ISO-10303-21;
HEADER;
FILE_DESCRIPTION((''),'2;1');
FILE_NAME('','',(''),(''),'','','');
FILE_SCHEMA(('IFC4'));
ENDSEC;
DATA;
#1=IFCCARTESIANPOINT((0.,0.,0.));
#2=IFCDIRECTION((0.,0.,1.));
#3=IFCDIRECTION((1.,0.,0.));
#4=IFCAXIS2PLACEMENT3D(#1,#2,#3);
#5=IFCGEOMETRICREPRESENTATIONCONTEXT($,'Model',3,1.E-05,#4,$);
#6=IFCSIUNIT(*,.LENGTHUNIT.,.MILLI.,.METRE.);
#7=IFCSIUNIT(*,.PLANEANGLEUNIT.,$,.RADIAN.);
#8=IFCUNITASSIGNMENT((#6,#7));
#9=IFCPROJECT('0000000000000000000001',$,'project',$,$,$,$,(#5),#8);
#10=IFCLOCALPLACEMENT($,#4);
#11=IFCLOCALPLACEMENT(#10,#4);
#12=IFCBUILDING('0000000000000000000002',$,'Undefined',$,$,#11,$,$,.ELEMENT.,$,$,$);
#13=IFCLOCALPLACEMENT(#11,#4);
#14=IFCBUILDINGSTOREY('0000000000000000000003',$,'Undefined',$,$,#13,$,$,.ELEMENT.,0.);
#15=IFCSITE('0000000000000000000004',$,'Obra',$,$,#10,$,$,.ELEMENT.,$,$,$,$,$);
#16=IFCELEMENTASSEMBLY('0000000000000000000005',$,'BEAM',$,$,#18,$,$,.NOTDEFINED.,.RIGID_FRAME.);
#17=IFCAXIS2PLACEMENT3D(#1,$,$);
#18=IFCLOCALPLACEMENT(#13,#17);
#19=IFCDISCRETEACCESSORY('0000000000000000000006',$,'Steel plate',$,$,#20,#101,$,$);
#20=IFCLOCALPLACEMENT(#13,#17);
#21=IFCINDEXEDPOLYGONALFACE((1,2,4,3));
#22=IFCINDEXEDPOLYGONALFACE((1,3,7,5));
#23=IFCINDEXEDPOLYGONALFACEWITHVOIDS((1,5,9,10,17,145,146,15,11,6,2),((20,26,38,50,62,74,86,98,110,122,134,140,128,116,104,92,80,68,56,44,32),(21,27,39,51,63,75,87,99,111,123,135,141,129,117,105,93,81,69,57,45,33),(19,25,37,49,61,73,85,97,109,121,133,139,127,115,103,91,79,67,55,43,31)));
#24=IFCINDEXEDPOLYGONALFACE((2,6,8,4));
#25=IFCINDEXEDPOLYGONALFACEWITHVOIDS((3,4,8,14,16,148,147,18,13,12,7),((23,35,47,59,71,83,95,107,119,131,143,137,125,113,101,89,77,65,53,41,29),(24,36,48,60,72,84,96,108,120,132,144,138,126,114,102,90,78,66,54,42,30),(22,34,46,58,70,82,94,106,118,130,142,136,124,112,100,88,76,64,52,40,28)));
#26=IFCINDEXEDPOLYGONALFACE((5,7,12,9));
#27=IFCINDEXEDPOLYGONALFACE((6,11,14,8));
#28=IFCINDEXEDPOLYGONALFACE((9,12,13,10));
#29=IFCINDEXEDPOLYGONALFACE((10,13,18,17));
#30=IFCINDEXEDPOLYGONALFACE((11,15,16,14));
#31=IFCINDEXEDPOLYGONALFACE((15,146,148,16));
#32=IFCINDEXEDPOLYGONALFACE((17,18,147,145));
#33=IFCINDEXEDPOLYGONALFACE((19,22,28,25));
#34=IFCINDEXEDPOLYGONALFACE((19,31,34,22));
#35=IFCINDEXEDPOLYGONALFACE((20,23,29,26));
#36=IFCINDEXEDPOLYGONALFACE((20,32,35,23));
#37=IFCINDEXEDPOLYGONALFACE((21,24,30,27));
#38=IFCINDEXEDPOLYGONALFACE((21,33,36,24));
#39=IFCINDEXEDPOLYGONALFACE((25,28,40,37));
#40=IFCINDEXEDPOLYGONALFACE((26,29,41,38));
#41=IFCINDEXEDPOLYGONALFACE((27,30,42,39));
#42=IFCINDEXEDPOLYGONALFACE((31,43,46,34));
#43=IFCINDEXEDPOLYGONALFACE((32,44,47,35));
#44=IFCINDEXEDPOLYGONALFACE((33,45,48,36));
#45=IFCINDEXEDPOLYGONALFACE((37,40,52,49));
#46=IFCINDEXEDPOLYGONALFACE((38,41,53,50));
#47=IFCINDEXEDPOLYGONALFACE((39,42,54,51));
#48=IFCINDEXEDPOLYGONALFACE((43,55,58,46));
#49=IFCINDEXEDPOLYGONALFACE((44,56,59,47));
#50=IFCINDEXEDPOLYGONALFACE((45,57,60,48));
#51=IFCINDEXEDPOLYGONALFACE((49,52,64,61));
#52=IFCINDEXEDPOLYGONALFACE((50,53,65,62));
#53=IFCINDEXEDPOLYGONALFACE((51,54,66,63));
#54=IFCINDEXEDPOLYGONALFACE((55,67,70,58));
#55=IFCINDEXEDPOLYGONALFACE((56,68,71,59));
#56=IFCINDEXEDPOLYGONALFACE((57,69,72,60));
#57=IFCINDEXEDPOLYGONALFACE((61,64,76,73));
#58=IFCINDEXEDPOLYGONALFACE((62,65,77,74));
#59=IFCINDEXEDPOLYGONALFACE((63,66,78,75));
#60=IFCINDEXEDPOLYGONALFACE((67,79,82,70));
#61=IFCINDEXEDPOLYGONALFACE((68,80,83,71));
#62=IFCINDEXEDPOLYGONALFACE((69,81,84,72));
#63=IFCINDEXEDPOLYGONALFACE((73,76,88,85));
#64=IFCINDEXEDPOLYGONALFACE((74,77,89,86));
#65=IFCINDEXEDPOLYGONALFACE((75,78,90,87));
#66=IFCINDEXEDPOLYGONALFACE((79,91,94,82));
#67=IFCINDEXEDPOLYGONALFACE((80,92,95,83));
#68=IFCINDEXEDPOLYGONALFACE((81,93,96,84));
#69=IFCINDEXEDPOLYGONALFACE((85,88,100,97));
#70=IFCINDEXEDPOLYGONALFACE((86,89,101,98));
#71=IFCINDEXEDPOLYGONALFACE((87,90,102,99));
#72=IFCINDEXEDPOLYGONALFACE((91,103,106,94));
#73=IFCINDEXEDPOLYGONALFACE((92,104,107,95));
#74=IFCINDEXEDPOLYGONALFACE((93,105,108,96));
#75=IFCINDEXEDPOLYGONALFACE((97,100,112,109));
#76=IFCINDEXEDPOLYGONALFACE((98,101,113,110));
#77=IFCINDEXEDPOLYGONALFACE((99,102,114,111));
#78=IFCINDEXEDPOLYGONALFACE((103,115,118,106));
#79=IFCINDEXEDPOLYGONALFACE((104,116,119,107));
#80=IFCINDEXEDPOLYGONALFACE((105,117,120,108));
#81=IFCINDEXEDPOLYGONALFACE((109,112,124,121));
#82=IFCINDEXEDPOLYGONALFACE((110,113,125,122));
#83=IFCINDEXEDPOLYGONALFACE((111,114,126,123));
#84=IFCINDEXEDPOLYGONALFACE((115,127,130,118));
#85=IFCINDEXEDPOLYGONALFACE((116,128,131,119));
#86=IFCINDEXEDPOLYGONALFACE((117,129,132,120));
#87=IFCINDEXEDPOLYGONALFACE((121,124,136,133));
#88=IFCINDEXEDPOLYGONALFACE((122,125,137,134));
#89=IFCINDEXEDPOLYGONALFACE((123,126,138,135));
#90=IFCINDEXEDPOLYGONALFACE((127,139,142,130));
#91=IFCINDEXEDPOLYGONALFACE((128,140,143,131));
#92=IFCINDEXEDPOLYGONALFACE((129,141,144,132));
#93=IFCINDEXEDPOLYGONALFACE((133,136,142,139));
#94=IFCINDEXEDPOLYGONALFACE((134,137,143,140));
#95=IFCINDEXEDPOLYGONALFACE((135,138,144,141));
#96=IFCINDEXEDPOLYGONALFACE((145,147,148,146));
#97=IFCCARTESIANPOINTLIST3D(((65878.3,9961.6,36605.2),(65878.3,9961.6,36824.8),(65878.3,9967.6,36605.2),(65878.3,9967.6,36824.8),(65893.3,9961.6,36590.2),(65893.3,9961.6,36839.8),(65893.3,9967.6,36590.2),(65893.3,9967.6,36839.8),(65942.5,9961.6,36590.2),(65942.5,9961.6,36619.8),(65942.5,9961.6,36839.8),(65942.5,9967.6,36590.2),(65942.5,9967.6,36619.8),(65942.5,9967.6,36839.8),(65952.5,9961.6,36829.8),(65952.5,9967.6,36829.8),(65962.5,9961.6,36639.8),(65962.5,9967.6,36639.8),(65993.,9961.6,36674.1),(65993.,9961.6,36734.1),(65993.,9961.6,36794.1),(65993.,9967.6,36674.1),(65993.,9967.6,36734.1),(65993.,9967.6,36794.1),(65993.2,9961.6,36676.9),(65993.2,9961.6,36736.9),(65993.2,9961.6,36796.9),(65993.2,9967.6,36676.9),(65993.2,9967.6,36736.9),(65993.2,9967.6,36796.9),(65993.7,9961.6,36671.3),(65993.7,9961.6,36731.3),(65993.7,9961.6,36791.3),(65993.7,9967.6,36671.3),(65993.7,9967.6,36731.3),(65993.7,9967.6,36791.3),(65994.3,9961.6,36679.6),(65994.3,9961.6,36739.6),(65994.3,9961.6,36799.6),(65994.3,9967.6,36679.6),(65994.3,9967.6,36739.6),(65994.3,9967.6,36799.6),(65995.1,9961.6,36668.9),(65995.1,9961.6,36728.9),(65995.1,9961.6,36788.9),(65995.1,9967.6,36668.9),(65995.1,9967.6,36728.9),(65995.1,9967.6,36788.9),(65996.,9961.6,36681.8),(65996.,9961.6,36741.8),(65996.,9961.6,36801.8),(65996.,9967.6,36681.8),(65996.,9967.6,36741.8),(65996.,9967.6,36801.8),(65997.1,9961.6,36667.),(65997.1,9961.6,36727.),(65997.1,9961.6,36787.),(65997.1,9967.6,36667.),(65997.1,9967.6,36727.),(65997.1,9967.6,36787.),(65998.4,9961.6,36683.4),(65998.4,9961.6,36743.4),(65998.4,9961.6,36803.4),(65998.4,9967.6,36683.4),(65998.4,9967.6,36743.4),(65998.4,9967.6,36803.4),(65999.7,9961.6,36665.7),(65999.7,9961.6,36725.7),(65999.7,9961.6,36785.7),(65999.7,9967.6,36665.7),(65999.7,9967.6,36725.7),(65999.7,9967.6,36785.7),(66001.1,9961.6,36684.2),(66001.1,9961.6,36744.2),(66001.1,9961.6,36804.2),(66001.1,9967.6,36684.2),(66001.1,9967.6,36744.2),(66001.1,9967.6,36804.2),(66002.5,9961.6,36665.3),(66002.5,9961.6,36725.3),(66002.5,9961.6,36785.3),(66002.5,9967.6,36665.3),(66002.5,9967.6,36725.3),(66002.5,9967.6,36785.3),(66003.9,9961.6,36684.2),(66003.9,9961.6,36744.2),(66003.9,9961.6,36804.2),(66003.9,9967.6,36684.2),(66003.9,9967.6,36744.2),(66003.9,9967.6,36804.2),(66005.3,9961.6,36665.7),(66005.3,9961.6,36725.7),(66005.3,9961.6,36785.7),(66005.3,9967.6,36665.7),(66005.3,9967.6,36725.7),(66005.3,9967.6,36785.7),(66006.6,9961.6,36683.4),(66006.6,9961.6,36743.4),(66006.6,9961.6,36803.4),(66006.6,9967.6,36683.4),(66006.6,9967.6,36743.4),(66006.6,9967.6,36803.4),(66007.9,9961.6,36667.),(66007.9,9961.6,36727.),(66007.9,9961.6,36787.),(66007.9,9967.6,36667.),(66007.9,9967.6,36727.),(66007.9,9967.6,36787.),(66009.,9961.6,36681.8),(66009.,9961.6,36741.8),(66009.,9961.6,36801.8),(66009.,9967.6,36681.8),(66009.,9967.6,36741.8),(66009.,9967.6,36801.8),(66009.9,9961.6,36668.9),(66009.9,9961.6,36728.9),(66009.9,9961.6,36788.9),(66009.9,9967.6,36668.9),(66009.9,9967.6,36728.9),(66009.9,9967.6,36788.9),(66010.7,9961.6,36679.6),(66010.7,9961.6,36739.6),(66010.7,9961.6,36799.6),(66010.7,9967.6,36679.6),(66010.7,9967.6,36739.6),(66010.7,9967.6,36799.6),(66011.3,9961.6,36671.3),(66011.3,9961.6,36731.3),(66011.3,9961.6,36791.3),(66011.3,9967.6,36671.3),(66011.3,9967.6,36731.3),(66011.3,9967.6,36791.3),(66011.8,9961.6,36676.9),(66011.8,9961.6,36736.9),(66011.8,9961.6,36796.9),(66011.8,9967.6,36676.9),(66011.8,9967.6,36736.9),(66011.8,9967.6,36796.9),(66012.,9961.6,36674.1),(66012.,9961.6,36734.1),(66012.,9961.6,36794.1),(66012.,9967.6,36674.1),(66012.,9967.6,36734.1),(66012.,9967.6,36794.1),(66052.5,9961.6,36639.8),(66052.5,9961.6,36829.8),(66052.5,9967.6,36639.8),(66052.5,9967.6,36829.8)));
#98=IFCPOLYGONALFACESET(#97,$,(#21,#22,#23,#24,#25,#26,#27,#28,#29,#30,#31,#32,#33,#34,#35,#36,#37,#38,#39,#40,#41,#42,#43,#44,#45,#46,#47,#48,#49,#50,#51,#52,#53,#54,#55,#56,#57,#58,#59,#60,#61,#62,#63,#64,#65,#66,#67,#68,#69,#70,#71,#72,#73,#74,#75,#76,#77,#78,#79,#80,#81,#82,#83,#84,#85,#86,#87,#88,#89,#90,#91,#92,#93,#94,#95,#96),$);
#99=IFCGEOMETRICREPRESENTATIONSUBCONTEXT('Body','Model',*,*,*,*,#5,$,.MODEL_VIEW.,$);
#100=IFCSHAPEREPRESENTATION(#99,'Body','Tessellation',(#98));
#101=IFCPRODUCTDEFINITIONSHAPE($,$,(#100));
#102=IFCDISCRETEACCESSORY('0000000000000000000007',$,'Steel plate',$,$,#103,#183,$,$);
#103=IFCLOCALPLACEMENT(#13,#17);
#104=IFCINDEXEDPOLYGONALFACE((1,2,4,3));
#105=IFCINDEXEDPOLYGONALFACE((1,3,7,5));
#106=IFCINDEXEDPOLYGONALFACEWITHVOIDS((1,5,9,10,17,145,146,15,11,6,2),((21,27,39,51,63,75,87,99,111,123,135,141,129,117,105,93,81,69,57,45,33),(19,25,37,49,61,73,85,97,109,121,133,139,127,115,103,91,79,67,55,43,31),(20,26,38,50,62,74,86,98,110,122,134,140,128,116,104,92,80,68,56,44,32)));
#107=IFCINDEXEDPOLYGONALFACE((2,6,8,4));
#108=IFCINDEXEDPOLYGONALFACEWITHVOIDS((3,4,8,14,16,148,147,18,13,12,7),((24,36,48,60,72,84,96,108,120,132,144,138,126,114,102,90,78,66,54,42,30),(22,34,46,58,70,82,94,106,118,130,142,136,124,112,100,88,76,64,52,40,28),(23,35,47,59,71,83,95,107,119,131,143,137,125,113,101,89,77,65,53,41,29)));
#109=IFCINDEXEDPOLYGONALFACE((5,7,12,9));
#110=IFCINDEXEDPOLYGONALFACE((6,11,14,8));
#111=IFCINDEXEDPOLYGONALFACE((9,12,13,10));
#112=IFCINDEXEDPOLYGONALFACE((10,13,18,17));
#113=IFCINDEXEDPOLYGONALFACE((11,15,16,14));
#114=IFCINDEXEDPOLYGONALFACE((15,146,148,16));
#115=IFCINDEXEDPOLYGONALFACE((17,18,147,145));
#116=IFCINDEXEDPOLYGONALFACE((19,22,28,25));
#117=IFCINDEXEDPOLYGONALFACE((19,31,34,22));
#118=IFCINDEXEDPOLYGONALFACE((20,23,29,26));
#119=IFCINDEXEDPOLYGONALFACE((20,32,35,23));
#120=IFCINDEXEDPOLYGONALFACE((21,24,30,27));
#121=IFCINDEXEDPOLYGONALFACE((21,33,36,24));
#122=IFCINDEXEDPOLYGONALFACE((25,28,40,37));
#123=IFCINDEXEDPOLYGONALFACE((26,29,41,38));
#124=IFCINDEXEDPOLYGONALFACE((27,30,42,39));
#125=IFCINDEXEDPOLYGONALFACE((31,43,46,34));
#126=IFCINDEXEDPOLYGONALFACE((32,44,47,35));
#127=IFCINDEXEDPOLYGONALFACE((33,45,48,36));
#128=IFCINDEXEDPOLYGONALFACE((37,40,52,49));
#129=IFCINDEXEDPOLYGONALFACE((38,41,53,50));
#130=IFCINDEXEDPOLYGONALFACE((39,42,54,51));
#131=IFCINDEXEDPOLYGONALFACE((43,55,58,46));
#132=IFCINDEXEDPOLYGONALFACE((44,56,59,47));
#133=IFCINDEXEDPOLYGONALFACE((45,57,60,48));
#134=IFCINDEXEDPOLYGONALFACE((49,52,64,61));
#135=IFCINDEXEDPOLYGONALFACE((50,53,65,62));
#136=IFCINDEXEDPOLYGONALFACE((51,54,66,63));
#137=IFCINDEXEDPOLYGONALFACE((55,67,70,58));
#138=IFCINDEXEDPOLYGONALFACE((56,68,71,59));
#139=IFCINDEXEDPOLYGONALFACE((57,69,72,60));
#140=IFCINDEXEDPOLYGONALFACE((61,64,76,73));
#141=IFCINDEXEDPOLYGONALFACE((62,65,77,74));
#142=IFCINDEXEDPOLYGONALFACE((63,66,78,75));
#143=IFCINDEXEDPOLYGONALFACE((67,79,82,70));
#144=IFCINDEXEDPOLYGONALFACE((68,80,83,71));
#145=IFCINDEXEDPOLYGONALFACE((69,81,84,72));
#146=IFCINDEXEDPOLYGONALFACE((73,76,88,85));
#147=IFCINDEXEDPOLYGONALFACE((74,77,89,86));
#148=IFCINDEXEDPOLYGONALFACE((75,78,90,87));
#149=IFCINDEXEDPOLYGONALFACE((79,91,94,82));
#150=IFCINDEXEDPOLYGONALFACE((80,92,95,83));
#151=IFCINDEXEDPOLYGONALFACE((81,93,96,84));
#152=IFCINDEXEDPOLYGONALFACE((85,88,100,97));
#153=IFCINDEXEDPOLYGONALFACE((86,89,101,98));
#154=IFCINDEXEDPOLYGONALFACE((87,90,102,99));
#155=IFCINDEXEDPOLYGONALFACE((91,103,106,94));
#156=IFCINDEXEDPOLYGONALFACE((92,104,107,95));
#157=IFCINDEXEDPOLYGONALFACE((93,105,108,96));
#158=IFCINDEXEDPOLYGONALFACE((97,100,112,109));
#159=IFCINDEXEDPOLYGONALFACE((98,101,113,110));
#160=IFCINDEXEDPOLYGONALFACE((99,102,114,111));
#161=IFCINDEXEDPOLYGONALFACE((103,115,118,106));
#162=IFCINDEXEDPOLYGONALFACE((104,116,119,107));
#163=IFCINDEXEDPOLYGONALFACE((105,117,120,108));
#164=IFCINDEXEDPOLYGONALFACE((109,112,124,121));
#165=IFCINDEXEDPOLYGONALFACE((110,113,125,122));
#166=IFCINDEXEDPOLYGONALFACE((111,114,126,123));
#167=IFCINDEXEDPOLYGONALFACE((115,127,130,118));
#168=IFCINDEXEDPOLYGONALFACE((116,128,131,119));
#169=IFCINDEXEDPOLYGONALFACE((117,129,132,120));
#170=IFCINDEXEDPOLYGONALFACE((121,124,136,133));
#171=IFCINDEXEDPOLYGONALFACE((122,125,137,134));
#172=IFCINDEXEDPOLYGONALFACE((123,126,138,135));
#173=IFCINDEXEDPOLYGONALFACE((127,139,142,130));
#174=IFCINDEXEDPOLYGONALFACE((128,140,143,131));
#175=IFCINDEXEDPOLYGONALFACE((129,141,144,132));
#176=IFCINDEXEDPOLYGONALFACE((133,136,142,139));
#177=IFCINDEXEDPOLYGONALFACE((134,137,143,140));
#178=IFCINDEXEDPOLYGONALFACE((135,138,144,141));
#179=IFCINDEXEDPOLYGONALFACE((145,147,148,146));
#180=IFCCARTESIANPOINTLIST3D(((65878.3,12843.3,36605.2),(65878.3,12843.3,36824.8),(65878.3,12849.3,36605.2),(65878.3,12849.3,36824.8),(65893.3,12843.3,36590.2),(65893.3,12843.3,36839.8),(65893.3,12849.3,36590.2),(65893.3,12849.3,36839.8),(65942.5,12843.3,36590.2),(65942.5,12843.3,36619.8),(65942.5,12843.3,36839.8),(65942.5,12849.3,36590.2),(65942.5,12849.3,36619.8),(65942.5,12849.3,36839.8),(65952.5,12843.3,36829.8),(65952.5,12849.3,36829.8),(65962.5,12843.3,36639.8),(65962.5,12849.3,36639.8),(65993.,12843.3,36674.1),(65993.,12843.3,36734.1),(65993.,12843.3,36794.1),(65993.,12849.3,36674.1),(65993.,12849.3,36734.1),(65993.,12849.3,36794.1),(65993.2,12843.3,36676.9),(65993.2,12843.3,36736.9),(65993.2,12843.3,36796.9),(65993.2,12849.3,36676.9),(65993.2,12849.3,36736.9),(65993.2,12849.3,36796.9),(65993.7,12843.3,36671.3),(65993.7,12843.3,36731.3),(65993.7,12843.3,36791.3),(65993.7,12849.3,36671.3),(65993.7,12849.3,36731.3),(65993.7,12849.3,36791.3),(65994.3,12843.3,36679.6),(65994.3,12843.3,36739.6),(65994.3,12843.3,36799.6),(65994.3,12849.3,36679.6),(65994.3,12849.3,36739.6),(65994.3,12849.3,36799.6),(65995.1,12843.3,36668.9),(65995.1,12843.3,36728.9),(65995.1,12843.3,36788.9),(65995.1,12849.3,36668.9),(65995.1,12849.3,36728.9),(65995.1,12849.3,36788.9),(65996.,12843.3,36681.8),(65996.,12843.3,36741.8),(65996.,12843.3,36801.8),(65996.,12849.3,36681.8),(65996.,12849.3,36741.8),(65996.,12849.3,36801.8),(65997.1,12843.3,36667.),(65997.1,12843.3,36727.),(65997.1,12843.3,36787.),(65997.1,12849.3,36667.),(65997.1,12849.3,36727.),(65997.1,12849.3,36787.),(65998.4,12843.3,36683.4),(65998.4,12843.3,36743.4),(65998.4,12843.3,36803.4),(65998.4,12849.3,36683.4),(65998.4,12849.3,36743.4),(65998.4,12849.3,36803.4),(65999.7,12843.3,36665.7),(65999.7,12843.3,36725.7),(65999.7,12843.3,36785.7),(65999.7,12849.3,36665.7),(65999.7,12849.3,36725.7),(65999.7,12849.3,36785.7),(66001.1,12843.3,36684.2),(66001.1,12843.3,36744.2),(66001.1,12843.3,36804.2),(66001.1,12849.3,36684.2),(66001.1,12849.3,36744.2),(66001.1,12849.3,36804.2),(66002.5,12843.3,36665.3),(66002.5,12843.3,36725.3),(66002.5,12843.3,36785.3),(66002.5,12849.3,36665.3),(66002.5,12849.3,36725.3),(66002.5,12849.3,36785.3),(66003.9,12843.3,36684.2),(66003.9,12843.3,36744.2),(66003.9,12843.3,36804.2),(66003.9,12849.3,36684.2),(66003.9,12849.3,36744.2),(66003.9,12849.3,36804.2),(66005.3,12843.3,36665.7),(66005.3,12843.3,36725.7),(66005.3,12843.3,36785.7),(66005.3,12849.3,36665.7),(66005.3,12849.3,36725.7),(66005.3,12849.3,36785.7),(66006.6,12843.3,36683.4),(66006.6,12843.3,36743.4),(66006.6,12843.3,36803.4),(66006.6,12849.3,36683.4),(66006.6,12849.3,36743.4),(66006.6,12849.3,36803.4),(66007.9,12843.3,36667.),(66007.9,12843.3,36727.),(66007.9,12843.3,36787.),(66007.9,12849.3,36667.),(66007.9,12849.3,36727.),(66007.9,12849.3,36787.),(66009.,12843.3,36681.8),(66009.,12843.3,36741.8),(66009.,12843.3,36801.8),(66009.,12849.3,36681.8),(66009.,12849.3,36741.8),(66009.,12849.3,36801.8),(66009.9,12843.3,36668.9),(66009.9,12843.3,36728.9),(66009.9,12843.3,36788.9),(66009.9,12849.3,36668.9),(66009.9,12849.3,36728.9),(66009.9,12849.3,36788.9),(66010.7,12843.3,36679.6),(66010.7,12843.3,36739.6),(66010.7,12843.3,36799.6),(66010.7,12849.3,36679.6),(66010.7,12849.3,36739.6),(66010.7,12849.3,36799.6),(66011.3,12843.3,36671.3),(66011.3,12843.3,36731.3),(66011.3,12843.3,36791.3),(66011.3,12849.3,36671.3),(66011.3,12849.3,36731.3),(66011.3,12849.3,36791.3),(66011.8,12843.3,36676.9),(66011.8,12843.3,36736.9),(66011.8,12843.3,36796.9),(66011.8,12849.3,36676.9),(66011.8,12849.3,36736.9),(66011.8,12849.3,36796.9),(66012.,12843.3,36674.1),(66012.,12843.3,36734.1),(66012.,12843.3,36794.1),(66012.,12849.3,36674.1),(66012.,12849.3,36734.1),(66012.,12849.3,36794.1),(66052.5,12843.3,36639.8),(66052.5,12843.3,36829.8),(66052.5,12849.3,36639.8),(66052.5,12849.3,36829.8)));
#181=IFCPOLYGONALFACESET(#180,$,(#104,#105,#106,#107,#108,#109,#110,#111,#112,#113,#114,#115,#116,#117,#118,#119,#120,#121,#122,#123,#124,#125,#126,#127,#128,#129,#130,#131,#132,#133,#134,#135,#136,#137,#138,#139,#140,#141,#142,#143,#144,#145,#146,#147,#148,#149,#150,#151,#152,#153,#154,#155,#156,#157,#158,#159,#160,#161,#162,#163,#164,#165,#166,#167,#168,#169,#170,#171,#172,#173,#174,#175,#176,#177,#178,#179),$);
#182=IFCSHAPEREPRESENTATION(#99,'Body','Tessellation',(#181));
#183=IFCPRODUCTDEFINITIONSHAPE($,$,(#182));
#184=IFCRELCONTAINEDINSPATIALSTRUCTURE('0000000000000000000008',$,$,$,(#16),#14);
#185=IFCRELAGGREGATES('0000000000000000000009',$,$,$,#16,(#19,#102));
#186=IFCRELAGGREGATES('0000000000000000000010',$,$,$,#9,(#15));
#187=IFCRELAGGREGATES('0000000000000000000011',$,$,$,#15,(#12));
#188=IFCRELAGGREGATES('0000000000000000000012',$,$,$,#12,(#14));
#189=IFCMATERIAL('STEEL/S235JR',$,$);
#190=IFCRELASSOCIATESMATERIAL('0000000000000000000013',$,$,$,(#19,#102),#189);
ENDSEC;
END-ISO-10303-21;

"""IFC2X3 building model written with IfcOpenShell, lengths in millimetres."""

from ifc_helpers import new_model, si_unit, frame, origin_with_axes, origin_2d_with_axis, place, context, subcontext, project, spatial, polyline, circle, outline, extrude, source, transform, mapped, material, element, aggregate, save


model = new_model("IFC2X3")

# Units and contexts
model_context = context("Model", 3, precision=1e-05, world=origin_with_axes())
body_context = subcontext(model_context, "Body", "Model", "MODEL_VIEW")
ifc_project = project(units=[si_unit("LENGTHUNIT", "METRE", prefix="MILLI"), si_unit("PLANEANGLEUNIT", "RADIAN")], contexts=[model_context])

# Site, building, storey
site_placement = place(None, origin_with_axes())
site = spatial("IfcSite", under=ifc_project, at=site_placement, Name="Obra", CompositionType="ELEMENT")
building_placement = place(site_placement, origin_with_axes())
building = spatial("IfcBuilding", under=site, at=building_placement, Name="Undefined", CompositionType="ELEMENT")
storey_placement = place(building_placement, origin_with_axes())
storey = spatial("IfcBuildingStorey", under=building, at=storey_placement, Name="Undefined", CompositionType="ELEMENT", Elevation=0.0)

# Element assembly
assembly_1_placement = place(storey_placement, origin_with_axes())
assembly_1 = element("IfcElementAssembly", 1, at=assembly_1_placement, inside=storey, Name="BEAM", AssemblyPlace="NOTDEFINED", PredefinedType="RIGID_FRAME")
ifc_material_1 = material(Name="STEEL/S235JR")

# Discrete accessories, openings
discrete_accessory_1_placement = place(assembly_1_placement, frame((65878.3, 9964.6, 36605.2), z_axis=(0.0, -1.0, 0.0), x_axis=(0.707107, 0.0, -0.707107)))
discrete_accessory_1 = element("IfcDiscreteAccessory", 2, at=discrete_accessory_1_placement, material=ifc_material_1, Name="Steel plate", context=body_context, shape_type="SweptSolid", body=[
    extrude(outline(polyline([(0.0, 0.0), (21.2, 0.0), (56.0, 34.8), (35.1, 55.7), (35.1, 84.0), (98.7, 147.6), (-35.6, 282.0), (-106.3, 211.3), (-120.5, 211.3), (-120.5, 211.3), (-155.3, 176.5), (-155.3, 155.3), (0.0, 0.0)])), frame((0.0, 0.0, -3.0), z_axis=(0.0, 0.0, 1.0), x_axis=(1.0, 0.0, 0.0)), (0.0, 0.0, 1.0), 6.0),
])
shared_shape_1 = source(origin_with_axes(), body_context, "Body", "SweptSolid", [
    extrude(circle(Radius=9.5, at=origin_2d_with_axis()), frame((0.0, 3.0, 0.0), z_axis=(0.0, 1.0, 0.0), x_axis=(1.0, 0.0, 0.0)), (0.0, 0.0, 1.0), 6.2),
])
opening_1_placement = place(assembly_1_placement, frame((65952.5, 9958.5, 36829.8), z_axis=(1.0, 0.0, 0.0), x_axis=(0.0, 0.0, -1.0)))
element("IfcOpeningElement", 3, at=opening_1_placement, cuts=discrete_accessory_1, ObjectType="Opening", context=body_context, shape_type="MappedRepresentation", body=[
    mapped(shared_shape_1, transform((35.0, 0.0, 50.0))),
    mapped(shared_shape_1, transform((95.0, 0.0, 50.0))),
    mapped(shared_shape_1, transform((155.0, 0.0, 50.0))),
])
discrete_accessory_2_placement = place(assembly_1_placement, frame((65878.3, 12846.3, 36605.2), z_axis=(0.0, -1.0, 0.0), x_axis=(0.707107, 0.0, -0.707107)))
discrete_accessory_2 = element("IfcDiscreteAccessory", 4, at=discrete_accessory_2_placement, material=ifc_material_1, Name="Steel plate", context=body_context, shape_type="SweptSolid", body=[
    extrude(outline(polyline([(0.0, 0.0), (21.2, 0.0), (56.0, 34.8), (35.1, 55.7), (35.1, 84.0), (98.7, 147.6), (-35.6, 282.0), (-106.3, 211.3), (-120.5, 211.3), (-120.5, 211.3), (-155.3, 176.5), (-155.3, 155.3), (0.0, 0.0)])), frame((0.0, 0.0, -3.0), z_axis=(0.0, 0.0, 1.0), x_axis=(1.0, 0.0, 0.0)), (0.0, 0.0, 1.0), 6.0),
])
shared_shape_2 = source(origin_with_axes(), body_context, "Body", "SweptSolid", [
    extrude(circle(Radius=9.5, at=origin_2d_with_axis()), frame((0.0, 3.0, 0.0), z_axis=(0.0, 1.0, 0.0), x_axis=(1.0, 0.0, 0.0)), (0.0, 0.0, 1.0), 6.2),
])
opening_2_placement = place(assembly_1_placement, frame((65952.5, 12840.2, 36829.8), z_axis=(1.0, 0.0, 0.0), x_axis=(0.0, 0.0, -1.0)))
element("IfcOpeningElement", 5, at=opening_2_placement, cuts=discrete_accessory_2, ObjectType="Opening", context=body_context, shape_type="MappedRepresentation", body=[
    mapped(shared_shape_2, transform((35.0, 0.0, 50.0))),
    mapped(shared_shape_2, transform((95.0, 0.0, 50.0))),
    mapped(shared_shape_2, transform((155.0, 0.0, 50.0))),
])
aggregate(assembly_1, [discrete_accessory_1, discrete_accessory_2])

save(model, "model.ifc")
